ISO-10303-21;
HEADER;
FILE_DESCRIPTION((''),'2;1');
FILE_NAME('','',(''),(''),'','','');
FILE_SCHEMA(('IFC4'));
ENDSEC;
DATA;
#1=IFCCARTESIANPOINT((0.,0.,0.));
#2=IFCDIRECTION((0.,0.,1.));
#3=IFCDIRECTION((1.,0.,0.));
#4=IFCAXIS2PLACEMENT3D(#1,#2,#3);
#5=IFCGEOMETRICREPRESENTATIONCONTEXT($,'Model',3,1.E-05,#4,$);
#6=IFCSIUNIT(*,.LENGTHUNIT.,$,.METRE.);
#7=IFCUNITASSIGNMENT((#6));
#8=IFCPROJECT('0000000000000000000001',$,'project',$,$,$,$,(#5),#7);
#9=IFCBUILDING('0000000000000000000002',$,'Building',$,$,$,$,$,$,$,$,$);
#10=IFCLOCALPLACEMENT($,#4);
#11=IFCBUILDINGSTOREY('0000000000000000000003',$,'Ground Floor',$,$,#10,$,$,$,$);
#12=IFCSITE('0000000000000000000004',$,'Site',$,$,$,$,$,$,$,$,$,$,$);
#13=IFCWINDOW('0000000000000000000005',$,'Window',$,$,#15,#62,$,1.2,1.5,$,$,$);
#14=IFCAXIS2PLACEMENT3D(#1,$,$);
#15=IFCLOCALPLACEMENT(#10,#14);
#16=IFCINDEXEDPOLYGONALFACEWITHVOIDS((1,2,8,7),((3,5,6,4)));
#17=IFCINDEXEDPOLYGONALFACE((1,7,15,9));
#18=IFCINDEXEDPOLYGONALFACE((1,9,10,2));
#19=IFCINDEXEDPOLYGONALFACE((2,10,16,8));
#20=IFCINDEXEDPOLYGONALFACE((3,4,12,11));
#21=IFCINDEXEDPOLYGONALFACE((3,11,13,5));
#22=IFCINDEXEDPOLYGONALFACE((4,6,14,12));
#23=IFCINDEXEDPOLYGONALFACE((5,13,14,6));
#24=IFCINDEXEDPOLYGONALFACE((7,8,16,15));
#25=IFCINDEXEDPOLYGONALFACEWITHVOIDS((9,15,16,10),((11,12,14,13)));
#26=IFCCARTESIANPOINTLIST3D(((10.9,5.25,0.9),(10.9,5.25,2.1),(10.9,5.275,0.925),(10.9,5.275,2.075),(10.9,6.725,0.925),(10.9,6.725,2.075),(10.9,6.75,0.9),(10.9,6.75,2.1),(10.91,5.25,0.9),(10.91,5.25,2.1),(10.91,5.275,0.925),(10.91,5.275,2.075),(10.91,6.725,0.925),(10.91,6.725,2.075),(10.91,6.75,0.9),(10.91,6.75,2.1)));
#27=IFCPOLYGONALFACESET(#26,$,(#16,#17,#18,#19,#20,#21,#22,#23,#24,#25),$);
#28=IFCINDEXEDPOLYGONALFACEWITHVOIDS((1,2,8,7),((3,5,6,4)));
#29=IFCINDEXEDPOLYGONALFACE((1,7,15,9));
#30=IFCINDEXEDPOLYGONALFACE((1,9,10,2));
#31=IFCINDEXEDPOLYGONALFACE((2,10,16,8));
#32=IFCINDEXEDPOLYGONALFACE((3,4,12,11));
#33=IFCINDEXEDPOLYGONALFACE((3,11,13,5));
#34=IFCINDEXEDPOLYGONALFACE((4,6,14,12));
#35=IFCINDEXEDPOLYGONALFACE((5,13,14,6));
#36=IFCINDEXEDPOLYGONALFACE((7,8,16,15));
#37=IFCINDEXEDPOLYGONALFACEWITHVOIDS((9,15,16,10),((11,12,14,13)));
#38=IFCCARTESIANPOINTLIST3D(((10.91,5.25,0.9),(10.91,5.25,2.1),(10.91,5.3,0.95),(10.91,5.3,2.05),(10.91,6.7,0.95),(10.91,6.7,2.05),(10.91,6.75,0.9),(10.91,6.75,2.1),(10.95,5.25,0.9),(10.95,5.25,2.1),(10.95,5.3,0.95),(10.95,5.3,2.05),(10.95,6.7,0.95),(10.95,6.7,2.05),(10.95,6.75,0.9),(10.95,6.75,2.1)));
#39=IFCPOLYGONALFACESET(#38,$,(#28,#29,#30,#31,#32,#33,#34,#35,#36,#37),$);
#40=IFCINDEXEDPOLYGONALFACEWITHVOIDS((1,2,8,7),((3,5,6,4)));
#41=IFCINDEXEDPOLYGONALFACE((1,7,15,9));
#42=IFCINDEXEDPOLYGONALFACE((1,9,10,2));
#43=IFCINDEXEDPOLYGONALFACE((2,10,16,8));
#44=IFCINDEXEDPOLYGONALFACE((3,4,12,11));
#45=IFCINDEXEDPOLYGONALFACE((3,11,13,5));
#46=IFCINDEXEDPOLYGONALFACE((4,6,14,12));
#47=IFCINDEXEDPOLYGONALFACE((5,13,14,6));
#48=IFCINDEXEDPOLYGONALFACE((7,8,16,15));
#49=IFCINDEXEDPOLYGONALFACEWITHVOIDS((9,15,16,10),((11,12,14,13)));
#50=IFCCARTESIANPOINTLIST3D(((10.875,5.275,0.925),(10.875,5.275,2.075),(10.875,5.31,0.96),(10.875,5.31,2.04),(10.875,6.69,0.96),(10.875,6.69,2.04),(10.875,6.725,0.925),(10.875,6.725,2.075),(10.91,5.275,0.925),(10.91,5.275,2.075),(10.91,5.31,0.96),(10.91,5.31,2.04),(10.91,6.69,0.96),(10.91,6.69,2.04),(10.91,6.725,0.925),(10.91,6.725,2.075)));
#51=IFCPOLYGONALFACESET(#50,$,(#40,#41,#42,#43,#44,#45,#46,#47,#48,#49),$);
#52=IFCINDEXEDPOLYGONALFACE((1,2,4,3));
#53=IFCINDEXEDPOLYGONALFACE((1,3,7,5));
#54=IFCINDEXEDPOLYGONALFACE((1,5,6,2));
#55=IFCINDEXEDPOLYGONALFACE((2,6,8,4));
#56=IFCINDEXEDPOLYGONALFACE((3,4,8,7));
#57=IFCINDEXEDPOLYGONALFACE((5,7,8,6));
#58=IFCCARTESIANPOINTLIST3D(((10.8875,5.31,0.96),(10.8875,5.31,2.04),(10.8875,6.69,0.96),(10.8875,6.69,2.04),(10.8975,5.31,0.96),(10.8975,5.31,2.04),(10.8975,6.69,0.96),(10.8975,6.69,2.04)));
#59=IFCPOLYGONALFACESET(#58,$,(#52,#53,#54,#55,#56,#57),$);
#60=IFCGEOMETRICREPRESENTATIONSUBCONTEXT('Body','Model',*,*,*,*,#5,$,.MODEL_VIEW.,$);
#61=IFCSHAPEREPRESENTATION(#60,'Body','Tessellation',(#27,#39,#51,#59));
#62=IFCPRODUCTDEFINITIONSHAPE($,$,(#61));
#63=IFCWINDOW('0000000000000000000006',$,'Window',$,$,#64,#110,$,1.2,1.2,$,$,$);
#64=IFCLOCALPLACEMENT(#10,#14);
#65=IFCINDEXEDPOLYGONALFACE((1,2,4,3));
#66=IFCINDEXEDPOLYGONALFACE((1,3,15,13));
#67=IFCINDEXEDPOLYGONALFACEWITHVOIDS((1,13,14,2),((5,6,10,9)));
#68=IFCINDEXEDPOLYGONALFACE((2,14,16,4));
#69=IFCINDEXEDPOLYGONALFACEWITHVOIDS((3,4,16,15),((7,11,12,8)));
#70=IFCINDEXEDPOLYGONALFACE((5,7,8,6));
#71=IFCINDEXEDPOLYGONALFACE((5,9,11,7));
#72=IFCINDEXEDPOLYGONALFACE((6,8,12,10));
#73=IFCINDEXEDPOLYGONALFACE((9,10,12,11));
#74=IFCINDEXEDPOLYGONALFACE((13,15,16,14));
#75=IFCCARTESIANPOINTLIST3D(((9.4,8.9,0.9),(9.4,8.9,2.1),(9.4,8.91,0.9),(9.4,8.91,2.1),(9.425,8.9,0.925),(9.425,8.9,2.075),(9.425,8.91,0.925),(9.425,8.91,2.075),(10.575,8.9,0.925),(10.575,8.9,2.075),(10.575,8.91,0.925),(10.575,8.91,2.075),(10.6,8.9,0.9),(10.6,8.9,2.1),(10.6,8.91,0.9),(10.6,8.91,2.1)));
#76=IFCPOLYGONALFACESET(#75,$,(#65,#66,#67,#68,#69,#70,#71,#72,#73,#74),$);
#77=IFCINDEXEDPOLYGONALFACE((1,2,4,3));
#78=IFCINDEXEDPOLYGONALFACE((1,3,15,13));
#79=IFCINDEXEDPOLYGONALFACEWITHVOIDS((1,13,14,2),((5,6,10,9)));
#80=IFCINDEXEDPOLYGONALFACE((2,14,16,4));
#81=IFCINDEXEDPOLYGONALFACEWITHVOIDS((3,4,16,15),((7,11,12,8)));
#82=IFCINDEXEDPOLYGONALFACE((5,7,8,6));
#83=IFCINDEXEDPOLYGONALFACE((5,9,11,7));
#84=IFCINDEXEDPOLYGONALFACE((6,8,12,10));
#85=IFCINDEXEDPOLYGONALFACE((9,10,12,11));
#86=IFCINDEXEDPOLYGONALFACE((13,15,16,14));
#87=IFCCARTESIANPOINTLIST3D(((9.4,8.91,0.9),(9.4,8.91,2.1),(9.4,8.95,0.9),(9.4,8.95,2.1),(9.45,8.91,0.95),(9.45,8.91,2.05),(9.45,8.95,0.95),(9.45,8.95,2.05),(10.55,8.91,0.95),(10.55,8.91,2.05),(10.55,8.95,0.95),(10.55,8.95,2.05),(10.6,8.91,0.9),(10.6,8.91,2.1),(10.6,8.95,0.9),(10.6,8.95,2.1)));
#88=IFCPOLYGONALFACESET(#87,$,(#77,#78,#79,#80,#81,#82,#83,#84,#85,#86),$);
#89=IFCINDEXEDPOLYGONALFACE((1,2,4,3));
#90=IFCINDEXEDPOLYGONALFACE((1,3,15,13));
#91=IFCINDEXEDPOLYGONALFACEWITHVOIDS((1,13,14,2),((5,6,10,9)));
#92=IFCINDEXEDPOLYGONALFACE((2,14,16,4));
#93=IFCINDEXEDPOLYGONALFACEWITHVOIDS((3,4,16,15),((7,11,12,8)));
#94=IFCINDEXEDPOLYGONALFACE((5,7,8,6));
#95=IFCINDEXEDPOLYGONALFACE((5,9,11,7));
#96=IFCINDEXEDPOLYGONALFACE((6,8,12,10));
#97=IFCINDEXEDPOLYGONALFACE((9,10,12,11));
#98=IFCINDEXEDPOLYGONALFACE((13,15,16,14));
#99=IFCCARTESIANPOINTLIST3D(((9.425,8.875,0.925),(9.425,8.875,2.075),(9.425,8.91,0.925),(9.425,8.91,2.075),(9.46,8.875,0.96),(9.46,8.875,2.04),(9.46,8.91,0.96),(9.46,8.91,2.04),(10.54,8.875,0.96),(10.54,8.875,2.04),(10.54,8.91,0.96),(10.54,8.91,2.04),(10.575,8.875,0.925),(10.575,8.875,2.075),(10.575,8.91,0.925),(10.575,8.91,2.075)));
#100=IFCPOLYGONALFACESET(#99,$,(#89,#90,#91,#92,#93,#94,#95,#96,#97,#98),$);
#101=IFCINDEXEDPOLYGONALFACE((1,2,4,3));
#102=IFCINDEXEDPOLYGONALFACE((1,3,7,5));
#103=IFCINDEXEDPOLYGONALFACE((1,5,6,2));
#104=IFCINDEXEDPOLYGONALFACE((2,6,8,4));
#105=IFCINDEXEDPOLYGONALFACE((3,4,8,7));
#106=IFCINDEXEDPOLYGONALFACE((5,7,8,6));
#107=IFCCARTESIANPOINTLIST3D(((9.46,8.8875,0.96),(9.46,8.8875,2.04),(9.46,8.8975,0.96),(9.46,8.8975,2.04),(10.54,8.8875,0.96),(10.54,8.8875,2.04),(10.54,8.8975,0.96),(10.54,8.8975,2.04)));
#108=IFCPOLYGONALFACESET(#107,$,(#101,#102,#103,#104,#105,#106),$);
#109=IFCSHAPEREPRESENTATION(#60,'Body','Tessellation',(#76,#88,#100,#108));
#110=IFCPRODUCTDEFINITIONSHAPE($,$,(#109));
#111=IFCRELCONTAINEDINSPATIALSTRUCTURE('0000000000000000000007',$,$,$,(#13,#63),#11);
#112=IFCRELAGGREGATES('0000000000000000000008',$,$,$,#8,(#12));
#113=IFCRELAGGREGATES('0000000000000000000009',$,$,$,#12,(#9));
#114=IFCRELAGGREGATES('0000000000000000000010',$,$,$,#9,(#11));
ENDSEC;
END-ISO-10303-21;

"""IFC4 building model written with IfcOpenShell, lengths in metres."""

from ifc_helpers import new_model, si_unit, frame, origin_with_axes, place, context, subcontext, project, spatial, line, indexed_curve, outline, extrude, element, save


model = new_model("IFC4")

# Units and contexts
model_context = context("Model", 3, precision=1e-05, world=origin_with_axes())
body_context = subcontext(model_context, "Body", "Model", "MODEL_VIEW")
ifc_project = project(units=[si_unit("LENGTHUNIT", "METRE")], contexts=[model_context])

# Site, building, storey
site = spatial("IfcSite", under=ifc_project, Name="Site")
building = spatial("IfcBuilding", under=site, Name="Building")
storey_placement = place(None, origin_with_axes())
storey = spatial("IfcBuildingStorey", under=building, at=storey_placement, Name="Ground Floor")

# Windows
window_1_placement = place(storey_placement, frame((11.0, 5.25, 0.9), z_axis=(0.0, 0.0, 1.0), x_axis=(0.0, 1.0, 0.0)))
element("IfcWindow", 1, at=window_1_placement, inside=storey, Name="Window", OverallHeight=1.2, OverallWidth=1.5, context=body_context, shape_type="SweptSolid", body=[
    extrude(outline(indexed_curve([(0.0, 0.0), (1.5, 0.0), (1.5, 1.2), (0.0, 1.2)], segments=[line(1, 2, 3, 4, 1)]), holes=[indexed_curve([(0.025, 0.025), (1.475, 0.025), (1.475, 1.175), (0.025, 1.175)], segments=[line(1, 2, 3, 4, 1)])]), frame((0.0, 0.09, 0.0), z_axis=(0.0, -1.0, 0.0), x_axis=(1.0, 0.0, 0.0)), (0.0, 0.0, -1.0), 0.01),
    extrude(outline(indexed_curve([(0.0, 0.0), (1.5, 0.0), (1.5, 1.2), (0.0, 1.2)], segments=[line(1, 2, 3, 4, 1)]), holes=[indexed_curve([(0.05, 0.05), (1.45, 0.05), (1.45, 1.15), (0.05, 1.15)], segments=[line(1, 2, 3, 4, 1)])]), frame((0.0, 0.05, 0.0), z_axis=(0.0, -1.0, 0.0), x_axis=(1.0, 0.0, 0.0)), (0.0, 0.0, -1.0), 0.04),
    extrude(outline(indexed_curve([(0.0, 0.0), (1.45, 0.0), (1.45, 1.15), (0.0, 1.15)], segments=[line(1, 2, 3, 4, 1)]), holes=[indexed_curve([(0.035, 0.035), (1.415, 0.035), (1.415, 1.115), (0.035, 1.115)], segments=[line(1, 2, 3, 4, 1)])]), frame((0.025, 0.09, 0.025), z_axis=(0.0, -1.0, 0.0), x_axis=(1.0, 0.0, 0.0)), (0.0, 0.0, -1.0), 0.035),
    extrude(outline(indexed_curve([(0.035, 0.035), (1.415, 0.035), (1.415, 1.115), (0.035, 1.115)], segments=[line(1, 2, 3, 4, 1)])), frame((0.025, 0.1025, 0.025), z_axis=(0.0, -1.0, 0.0), x_axis=(1.0, 0.0, 0.0)), (0.0, 0.0, -1.0), 0.01),
])
window_2_placement = place(storey_placement, frame((10.6, 9.0, 0.9), z_axis=(0.0, 0.0, 1.0), x_axis=(-1.0, 0.0, 0.0)))
element("IfcWindow", 2, at=window_2_placement, inside=storey, Name="Window", OverallHeight=1.2, OverallWidth=1.2, context=body_context, shape_type="SweptSolid", body=[
    extrude(outline(indexed_curve([(0.0, 0.0), (1.2, 0.0), (1.2, 1.2), (0.0, 1.2)], segments=[line(1, 2, 3, 4, 1)]), holes=[indexed_curve([(0.025, 0.025), (1.175, 0.025), (1.175, 1.175), (0.025, 1.175)], segments=[line(1, 2, 3, 4, 1)])]), frame((0.0, 0.09, 0.0), z_axis=(0.0, -1.0, 0.0), x_axis=(1.0, 0.0, 0.0)), (0.0, 0.0, -1.0), 0.01),
    extrude(outline(indexed_curve([(0.0, 0.0), (1.2, 0.0), (1.2, 1.2), (0.0, 1.2)], segments=[line(1, 2, 3, 4, 1)]), holes=[indexed_curve([(0.05, 0.05), (1.15, 0.05), (1.15, 1.15), (0.05, 1.15)], segments=[line(1, 2, 3, 4, 1)])]), frame((0.0, 0.05, 0.0), z_axis=(0.0, -1.0, 0.0), x_axis=(1.0, 0.0, 0.0)), (0.0, 0.0, -1.0), 0.04),
    extrude(outline(indexed_curve([(0.0, 0.0), (1.15, 0.0), (1.15, 1.15), (0.0, 1.15)], segments=[line(1, 2, 3, 4, 1)]), holes=[indexed_curve([(0.035, 0.035), (1.115, 0.035), (1.115, 1.115), (0.035, 1.115)], segments=[line(1, 2, 3, 4, 1)])]), frame((0.025, 0.09, 0.025), z_axis=(0.0, -1.0, 0.0), x_axis=(1.0, 0.0, 0.0)), (0.0, 0.0, -1.0), 0.035),
    extrude(outline(indexed_curve([(0.035, 0.035), (1.115, 0.035), (1.115, 1.115), (0.035, 1.115)], segments=[line(1, 2, 3, 4, 1)])), frame((0.025, 0.1025, 0.025), z_axis=(0.0, -1.0, 0.0), x_axis=(1.0, 0.0, 0.0)), (0.0, 0.0, -1.0), 0.01),
])

save(model, "model.ifc")
